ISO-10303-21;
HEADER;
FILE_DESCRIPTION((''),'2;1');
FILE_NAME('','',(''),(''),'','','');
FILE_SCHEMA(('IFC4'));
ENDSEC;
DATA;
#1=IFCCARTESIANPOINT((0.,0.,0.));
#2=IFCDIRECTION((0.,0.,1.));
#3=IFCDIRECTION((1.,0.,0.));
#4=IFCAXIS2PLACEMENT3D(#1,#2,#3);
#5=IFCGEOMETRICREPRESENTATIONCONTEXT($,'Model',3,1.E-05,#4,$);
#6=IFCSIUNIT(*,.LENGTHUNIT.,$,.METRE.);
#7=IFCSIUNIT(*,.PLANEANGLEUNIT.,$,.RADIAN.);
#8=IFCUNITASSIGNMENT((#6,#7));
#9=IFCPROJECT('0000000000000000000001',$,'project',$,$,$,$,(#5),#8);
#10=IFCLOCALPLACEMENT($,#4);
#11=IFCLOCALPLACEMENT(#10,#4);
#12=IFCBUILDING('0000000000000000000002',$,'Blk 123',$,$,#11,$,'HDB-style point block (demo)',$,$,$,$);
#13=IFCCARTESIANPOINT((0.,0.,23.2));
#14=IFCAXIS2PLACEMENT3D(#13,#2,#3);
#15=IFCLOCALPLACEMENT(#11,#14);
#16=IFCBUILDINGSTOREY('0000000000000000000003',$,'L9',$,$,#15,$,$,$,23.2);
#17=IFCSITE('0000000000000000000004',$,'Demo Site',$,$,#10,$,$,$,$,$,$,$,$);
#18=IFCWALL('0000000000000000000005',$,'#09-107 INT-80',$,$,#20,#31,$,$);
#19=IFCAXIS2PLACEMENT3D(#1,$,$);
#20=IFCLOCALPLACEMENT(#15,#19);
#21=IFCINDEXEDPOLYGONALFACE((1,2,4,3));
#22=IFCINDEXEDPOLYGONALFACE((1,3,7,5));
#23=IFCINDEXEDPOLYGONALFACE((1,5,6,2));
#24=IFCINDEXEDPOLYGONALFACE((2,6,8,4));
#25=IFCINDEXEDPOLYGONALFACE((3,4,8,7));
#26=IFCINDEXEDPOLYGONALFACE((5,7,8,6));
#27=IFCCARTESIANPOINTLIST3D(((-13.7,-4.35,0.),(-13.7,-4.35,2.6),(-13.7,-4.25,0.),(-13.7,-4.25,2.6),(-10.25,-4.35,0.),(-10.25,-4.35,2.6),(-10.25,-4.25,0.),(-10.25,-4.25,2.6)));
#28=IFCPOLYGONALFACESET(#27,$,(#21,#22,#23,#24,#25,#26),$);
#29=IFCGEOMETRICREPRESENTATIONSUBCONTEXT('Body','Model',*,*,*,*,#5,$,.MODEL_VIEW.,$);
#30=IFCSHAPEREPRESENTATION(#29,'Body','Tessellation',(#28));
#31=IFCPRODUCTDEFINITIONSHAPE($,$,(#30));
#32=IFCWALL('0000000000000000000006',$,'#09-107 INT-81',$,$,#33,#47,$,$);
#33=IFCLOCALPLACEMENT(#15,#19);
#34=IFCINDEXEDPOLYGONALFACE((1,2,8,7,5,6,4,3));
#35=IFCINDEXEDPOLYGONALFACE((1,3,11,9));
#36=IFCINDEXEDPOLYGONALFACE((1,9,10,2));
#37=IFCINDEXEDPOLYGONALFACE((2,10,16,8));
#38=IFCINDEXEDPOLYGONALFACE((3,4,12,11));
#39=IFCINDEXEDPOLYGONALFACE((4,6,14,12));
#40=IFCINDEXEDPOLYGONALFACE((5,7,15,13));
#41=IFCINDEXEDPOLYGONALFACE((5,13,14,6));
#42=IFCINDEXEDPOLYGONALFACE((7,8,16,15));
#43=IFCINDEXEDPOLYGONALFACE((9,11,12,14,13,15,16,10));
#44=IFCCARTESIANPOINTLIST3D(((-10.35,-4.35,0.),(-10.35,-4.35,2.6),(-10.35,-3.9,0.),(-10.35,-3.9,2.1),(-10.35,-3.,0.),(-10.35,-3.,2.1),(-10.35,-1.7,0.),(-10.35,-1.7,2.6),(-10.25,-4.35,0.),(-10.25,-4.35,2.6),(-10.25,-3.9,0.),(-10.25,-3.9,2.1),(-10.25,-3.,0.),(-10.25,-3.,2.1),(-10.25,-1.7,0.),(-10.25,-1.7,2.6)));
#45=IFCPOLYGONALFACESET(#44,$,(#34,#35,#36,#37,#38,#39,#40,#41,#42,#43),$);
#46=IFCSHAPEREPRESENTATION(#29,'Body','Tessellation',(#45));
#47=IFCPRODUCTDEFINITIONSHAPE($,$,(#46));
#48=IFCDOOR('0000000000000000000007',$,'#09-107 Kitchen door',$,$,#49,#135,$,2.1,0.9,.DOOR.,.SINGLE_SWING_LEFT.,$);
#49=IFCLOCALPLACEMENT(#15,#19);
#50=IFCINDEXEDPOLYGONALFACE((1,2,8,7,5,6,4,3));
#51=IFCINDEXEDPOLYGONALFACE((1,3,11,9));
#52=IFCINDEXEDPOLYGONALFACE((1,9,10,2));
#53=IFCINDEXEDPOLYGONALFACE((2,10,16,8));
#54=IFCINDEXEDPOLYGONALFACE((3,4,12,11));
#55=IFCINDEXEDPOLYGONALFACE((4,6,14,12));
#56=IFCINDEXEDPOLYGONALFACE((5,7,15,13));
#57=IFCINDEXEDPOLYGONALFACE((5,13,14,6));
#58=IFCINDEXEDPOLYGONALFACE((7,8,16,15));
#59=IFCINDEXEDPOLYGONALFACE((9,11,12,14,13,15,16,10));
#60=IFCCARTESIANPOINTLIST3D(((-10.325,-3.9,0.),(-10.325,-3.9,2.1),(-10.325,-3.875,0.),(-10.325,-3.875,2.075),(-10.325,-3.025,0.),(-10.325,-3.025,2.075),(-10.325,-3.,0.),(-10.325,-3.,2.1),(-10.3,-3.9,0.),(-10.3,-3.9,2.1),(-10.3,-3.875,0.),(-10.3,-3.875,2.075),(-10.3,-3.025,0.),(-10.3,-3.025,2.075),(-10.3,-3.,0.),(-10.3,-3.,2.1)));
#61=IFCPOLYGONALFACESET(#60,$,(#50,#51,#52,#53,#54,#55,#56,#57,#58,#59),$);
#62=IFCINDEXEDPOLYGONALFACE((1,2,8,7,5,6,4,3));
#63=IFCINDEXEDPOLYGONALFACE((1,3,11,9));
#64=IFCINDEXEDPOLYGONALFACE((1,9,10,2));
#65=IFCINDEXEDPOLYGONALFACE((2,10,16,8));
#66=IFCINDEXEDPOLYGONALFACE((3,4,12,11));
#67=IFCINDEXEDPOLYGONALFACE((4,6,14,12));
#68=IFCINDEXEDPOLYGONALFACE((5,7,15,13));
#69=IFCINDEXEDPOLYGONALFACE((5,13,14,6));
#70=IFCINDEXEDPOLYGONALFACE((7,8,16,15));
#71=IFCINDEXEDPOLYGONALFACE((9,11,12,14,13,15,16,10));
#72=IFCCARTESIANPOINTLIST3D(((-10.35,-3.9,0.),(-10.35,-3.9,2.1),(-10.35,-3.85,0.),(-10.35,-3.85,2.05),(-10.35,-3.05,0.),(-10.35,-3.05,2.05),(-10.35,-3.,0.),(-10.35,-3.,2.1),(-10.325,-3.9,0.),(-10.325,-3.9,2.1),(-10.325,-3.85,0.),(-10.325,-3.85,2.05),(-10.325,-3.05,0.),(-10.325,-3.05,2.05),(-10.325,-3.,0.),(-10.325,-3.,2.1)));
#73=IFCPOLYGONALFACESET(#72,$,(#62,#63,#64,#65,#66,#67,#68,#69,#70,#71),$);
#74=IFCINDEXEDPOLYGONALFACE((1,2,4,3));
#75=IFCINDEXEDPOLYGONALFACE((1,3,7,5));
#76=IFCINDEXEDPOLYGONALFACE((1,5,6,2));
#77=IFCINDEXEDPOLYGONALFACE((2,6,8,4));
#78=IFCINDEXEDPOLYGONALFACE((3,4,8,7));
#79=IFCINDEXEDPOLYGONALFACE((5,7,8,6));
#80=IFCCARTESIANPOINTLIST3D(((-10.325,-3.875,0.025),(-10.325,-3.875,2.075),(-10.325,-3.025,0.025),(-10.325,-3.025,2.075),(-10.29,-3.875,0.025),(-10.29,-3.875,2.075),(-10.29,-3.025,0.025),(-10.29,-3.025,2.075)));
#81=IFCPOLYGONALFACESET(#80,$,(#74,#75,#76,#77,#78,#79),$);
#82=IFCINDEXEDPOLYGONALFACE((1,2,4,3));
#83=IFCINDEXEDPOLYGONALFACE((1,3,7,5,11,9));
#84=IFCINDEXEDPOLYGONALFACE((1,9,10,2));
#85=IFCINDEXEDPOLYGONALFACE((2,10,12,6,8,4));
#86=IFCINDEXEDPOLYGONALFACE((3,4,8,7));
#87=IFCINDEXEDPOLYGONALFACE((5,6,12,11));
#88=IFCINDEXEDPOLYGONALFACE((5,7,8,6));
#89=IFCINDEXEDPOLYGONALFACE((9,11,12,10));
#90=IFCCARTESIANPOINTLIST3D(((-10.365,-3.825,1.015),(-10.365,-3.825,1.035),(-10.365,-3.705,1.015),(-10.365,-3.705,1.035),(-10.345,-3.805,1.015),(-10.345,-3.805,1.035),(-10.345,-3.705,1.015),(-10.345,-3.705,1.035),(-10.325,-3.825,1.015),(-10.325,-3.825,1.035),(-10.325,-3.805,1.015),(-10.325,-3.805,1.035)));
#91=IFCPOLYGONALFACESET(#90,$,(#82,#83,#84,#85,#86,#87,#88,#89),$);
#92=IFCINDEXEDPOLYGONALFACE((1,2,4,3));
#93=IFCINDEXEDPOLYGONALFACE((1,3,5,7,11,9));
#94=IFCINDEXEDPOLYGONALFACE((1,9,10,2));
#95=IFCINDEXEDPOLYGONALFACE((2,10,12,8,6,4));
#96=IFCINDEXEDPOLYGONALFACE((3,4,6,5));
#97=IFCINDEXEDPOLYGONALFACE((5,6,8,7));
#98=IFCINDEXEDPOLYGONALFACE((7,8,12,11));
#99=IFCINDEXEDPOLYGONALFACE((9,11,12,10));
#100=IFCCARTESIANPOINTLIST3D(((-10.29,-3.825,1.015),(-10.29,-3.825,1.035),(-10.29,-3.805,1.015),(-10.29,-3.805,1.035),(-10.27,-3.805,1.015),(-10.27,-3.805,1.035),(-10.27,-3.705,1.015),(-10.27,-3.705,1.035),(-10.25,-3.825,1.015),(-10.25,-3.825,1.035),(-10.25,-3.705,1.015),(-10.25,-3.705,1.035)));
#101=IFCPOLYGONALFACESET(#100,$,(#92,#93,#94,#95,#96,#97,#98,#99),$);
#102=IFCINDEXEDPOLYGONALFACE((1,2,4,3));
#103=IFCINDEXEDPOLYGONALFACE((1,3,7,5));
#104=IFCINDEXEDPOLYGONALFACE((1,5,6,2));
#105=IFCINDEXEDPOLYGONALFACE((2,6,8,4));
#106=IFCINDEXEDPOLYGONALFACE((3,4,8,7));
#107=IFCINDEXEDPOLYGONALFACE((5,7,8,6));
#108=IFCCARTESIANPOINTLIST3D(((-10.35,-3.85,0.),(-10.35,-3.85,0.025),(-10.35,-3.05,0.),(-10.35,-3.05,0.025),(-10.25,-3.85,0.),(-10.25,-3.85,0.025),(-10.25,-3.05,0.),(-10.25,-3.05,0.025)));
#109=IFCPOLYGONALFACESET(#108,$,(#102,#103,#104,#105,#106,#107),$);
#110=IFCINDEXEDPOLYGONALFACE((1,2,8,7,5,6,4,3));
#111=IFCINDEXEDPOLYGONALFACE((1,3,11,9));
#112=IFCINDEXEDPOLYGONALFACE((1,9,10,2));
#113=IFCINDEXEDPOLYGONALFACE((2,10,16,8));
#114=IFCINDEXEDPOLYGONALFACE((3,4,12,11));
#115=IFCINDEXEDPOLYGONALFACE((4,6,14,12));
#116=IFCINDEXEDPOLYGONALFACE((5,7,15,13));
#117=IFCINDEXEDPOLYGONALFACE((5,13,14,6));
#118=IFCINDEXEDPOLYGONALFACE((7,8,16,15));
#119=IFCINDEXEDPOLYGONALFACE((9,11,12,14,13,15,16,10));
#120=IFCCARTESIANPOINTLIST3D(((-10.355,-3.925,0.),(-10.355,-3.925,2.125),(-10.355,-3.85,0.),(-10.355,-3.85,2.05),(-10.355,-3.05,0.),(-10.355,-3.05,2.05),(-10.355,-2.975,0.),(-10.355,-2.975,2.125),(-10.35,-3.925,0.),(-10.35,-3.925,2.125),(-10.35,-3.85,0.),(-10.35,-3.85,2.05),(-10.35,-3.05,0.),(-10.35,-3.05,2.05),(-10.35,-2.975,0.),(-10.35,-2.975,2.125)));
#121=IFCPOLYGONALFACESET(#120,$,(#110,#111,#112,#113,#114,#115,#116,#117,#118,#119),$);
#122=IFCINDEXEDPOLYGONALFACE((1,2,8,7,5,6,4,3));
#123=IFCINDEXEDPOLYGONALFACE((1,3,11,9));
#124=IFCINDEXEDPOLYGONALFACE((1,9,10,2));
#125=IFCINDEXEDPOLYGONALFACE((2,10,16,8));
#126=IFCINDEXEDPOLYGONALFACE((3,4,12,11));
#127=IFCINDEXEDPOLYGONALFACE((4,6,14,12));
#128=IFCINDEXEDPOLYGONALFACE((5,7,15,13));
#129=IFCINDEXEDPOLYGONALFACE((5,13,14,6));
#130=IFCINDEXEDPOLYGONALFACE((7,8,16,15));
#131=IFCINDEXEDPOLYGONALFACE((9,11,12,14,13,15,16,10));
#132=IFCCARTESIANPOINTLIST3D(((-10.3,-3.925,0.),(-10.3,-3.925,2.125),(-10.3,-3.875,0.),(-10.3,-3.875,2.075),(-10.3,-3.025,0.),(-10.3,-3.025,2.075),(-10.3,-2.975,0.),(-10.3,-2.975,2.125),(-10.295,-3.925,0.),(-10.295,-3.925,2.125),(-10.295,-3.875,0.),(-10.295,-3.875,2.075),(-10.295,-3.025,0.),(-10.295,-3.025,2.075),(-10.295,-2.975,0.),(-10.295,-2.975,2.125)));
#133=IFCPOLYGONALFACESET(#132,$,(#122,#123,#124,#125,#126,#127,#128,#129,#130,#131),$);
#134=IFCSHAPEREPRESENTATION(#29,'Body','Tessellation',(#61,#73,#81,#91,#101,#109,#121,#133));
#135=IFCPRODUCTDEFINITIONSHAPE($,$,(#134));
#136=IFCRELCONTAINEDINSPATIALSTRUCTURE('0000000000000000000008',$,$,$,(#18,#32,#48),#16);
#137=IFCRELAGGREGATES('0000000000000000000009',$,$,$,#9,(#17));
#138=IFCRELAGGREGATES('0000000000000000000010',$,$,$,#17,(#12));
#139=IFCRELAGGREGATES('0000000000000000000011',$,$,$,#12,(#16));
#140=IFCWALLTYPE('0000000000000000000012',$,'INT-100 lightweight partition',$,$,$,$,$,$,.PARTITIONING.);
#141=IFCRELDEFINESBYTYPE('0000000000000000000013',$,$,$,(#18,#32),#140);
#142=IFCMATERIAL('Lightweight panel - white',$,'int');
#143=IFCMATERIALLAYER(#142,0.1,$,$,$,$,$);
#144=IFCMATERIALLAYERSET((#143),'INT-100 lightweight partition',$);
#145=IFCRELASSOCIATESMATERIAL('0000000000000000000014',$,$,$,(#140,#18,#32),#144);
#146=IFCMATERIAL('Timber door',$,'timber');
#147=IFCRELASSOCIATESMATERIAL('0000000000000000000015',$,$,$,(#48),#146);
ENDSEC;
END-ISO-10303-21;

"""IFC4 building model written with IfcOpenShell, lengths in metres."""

from ifc_helpers import new_model, si_unit, frame, origin_with_axes, place, context, subcontext, project, spatial, line, indexed_curve, outline, extrude, material, layer, layer_set, layer_usage, type_object, element, fill, save


model = new_model("IFC4")

# Units and contexts
model_context = context("Model", 3, precision=1e-05, world=origin_with_axes())
body_context = subcontext(model_context, "Body", "Model", "MODEL_VIEW")
ifc_project = project(units=[si_unit("LENGTHUNIT", "METRE"), si_unit("PLANEANGLEUNIT", "RADIAN")], contexts=[model_context])

# Site, building, storey
site_placement = place(None, origin_with_axes())
site = spatial("IfcSite", under=ifc_project, at=site_placement, Name="Demo Site")
building_placement = place(site_placement, origin_with_axes())
building = spatial("IfcBuilding", under=site, at=building_placement, Name="Blk 123", LongName="HDB-style point block (demo)")
storey_placement = place(building_placement, frame((0.0, 0.0, 23.2), z_axis=(0.0, 0.0, 1.0), x_axis=(1.0, 0.0, 0.0)))
storey = spatial("IfcBuildingStorey", under=building, at=storey_placement, Name="L9", Elevation=23.2)

# Wall
ifc_material_1 = material(Name="Lightweight panel - white", Category="int")
ifc_layer_1 = layer(ifc_material_1, 0.1)
ifc_layer_set_1 = layer_set([ifc_layer_1], Name="INT-100 lightweight partition")
ifc_layer_usage_1 = layer_usage(ifc_layer_set_1, "AXIS2", "POSITIVE", -0.05)
wall_type_1 = type_object("IfcWallType", Name="INT-100 lightweight partition", PredefinedType="PARTITIONING", material=ifc_layer_set_1)
wall_1_placement = place(storey_placement, frame((-10.25, -4.3, 0.0), z_axis=(0.0, 0.0, 1.0), x_axis=(-1.0, 0.0, 0.0)))
element("IfcWall", 1, at=wall_1_placement, inside=storey, type_object=wall_type_1, material=ifc_layer_usage_1, Name="#09-107 INT-80", context=body_context, shape_type="SweptSolid", body=[
    extrude(outline(indexed_curve([(0.0, 0.0), (0.0, 0.1), (3.45, 0.1), (3.45, 0.0), (0.0, 0.0)], self_intersect=False)), frame((0.0, -0.05, 0.0), z_axis=(0.0, 0.0, 1.0), x_axis=(1.0, 0.0, 0.0)), (0.0, 0.0, 1.0), 2.6),
])

# Wall, opening, door
wall_2_placement = place(storey_placement, frame((-10.3, -1.7, 0.0), z_axis=(0.0, 0.0, 1.0), x_axis=(0.0, -1.0, 0.0)))
wall_2 = element("IfcWall", 2, at=wall_2_placement, inside=storey, type_object=wall_type_1, material=ifc_layer_usage_1, Name="#09-107 INT-81", context=body_context, shape_type="SweptSolid", body=[
    extrude(outline(indexed_curve([(0.0, 0.0), (0.0, 0.1), (2.65, 0.1), (2.65, 0.0), (0.0, 0.0)], self_intersect=False)), frame((0.0, -0.05, 0.0), z_axis=(0.0, 0.0, 1.0), x_axis=(1.0, 0.0, 0.0)), (0.0, 0.0, 1.0), 2.6),
])
opening_1_placement = place(wall_2_placement, frame((1.3, -0.15, 0.0), z_axis=(0.0, 0.0, 1.0), x_axis=(1.0, 0.0, 0.0)))
opening_1 = element("IfcOpeningElement", 3, at=opening_1_placement, cuts=wall_2, context=body_context, shape_type="SweptSolid", body=[
    extrude(outline(indexed_curve([(0.0, 0.0), (0.0, 0.3), (0.9, 0.3), (0.9, 0.0), (0.0, 0.0)], self_intersect=False)), origin_with_axes(), (0.0, 0.0, 1.0), 2.1),
])
ifc_material_2 = material(Name="Timber door", Category="timber")
door_1_placement = place(opening_1_placement, frame((0.0, 0.1, 0.0), z_axis=(0.0, 0.0, 1.0), x_axis=(1.0, 0.0, 0.0)))
door_1 = element("IfcDoor", 4, at=door_1_placement, inside=storey, material=ifc_material_2, Name="#09-107 Kitchen door", OperationType="SINGLE_SWING_LEFT", OverallHeight=2.1, OverallWidth=0.9, PredefinedType="DOOR", context=body_context, shape_type="SweptSolid", body=[
    extrude(outline(indexed_curve([(0.0, 0.0), (0.0, 2.1), (0.9, 2.1), (0.9, 0.0), (0.875, 0.0), (0.875, 2.075), (0.025, 2.075), (0.025, 0.0)], segments=[line(1, 2, 3, 4, 5, 6, 7, 8, 1)])), frame((0.0, 0.025, 0.0), z_axis=(0.0, -1.0, 0.0), x_axis=(1.0, 0.0, 0.0)), (0.0, 0.0, -1.0), 0.025),
    extrude(outline(indexed_curve([(0.0, 0.0), (0.0, 2.1), (0.9, 2.1), (0.9, 0.0), (0.85, 0.0), (0.85, 2.05), (0.05, 2.05), (0.05, 0.0)], segments=[line(1, 2, 3, 4, 5, 6, 7, 8, 1)])), frame((0.0, 0.0, 0.0), z_axis=(0.0, -1.0, 0.0), x_axis=(1.0, 0.0, 0.0)), (0.0, 0.0, -1.0), 0.025),
    extrude(outline(indexed_curve([(0.0, 0.0), (0.85, 0.0), (0.85, 0.035), (0.0, 0.035)], segments=[line(1, 2, 3, 4, 1)])), frame((0.025, 0.025, 0.025), z_axis=(0.0, 0.0, 1.0), x_axis=(1.0, 0.0, 0.0)), (0.0, 0.0, 1.0), 2.05),
    extrude(outline(indexed_curve([(0.0, 0.0), (0.0, -0.04), (-0.12, -0.04), (-0.12, -0.02), (-0.02, -0.02), (-0.02, 0.0)], segments=[line(1, 2, 3, 4, 5, 6, 1)])), frame((0.825, 0.025, 1.015), z_axis=(0.0, 0.0, 1.0), x_axis=(1.0, 0.0, 0.0)), (0.0, 0.0, 1.0), 0.02),
    extrude(outline(indexed_curve([(0.0, 0.0), (0.0, 0.04), (-0.12, 0.04), (-0.12, 0.02), (-0.02, 0.02), (-0.02, 0.0)], segments=[line(1, 2, 3, 4, 5, 6, 1)])), frame((0.825, 0.06, 1.015), z_axis=(0.0, 0.0, 1.0), x_axis=(1.0, 0.0, 0.0)), (0.0, 0.0, 1.0), 0.02),
    extrude(outline(indexed_curve([(0.0, 0.0), (0.8, 0.0), (0.8, 0.1), (0.0, 0.1)], segments=[line(1, 2, 3, 4, 1)])), frame((0.05, 0.0, 0.0), z_axis=(0.0, 0.0, 1.0), x_axis=(1.0, 0.0, 0.0)), (0.0, 0.0, 1.0), 0.025),
    extrude(outline(indexed_curve([(0.0, 0.0), (0.0, 2.125), (0.95, 2.125), (0.95, 0.0), (0.875, 0.0), (0.875, 2.05), (0.075, 2.05), (0.075, 0.0)], segments=[line(1, 2, 3, 4, 5, 6, 7, 8, 1)])), frame((-0.025, -0.005, 0.0), z_axis=(0.0, -1.0, 0.0), x_axis=(1.0, 0.0, 0.0)), (0.0, 0.0, -1.0), 0.005),
    extrude(outline(indexed_curve([(0.0, 0.0), (0.0, 2.125), (0.95, 2.125), (0.95, 0.0), (0.9, 0.0), (0.9, 2.075), (0.05, 2.075), (0.05, 0.0)], segments=[line(1, 2, 3, 4, 5, 6, 7, 8, 1)])), frame((-0.025, 0.05, 0.0), z_axis=(0.0, -1.0, 0.0), x_axis=(1.0, 0.0, 0.0)), (0.0, 0.0, -1.0), 0.005),
])
fill(opening_1, door_1)

save(model, "model.ifc")
